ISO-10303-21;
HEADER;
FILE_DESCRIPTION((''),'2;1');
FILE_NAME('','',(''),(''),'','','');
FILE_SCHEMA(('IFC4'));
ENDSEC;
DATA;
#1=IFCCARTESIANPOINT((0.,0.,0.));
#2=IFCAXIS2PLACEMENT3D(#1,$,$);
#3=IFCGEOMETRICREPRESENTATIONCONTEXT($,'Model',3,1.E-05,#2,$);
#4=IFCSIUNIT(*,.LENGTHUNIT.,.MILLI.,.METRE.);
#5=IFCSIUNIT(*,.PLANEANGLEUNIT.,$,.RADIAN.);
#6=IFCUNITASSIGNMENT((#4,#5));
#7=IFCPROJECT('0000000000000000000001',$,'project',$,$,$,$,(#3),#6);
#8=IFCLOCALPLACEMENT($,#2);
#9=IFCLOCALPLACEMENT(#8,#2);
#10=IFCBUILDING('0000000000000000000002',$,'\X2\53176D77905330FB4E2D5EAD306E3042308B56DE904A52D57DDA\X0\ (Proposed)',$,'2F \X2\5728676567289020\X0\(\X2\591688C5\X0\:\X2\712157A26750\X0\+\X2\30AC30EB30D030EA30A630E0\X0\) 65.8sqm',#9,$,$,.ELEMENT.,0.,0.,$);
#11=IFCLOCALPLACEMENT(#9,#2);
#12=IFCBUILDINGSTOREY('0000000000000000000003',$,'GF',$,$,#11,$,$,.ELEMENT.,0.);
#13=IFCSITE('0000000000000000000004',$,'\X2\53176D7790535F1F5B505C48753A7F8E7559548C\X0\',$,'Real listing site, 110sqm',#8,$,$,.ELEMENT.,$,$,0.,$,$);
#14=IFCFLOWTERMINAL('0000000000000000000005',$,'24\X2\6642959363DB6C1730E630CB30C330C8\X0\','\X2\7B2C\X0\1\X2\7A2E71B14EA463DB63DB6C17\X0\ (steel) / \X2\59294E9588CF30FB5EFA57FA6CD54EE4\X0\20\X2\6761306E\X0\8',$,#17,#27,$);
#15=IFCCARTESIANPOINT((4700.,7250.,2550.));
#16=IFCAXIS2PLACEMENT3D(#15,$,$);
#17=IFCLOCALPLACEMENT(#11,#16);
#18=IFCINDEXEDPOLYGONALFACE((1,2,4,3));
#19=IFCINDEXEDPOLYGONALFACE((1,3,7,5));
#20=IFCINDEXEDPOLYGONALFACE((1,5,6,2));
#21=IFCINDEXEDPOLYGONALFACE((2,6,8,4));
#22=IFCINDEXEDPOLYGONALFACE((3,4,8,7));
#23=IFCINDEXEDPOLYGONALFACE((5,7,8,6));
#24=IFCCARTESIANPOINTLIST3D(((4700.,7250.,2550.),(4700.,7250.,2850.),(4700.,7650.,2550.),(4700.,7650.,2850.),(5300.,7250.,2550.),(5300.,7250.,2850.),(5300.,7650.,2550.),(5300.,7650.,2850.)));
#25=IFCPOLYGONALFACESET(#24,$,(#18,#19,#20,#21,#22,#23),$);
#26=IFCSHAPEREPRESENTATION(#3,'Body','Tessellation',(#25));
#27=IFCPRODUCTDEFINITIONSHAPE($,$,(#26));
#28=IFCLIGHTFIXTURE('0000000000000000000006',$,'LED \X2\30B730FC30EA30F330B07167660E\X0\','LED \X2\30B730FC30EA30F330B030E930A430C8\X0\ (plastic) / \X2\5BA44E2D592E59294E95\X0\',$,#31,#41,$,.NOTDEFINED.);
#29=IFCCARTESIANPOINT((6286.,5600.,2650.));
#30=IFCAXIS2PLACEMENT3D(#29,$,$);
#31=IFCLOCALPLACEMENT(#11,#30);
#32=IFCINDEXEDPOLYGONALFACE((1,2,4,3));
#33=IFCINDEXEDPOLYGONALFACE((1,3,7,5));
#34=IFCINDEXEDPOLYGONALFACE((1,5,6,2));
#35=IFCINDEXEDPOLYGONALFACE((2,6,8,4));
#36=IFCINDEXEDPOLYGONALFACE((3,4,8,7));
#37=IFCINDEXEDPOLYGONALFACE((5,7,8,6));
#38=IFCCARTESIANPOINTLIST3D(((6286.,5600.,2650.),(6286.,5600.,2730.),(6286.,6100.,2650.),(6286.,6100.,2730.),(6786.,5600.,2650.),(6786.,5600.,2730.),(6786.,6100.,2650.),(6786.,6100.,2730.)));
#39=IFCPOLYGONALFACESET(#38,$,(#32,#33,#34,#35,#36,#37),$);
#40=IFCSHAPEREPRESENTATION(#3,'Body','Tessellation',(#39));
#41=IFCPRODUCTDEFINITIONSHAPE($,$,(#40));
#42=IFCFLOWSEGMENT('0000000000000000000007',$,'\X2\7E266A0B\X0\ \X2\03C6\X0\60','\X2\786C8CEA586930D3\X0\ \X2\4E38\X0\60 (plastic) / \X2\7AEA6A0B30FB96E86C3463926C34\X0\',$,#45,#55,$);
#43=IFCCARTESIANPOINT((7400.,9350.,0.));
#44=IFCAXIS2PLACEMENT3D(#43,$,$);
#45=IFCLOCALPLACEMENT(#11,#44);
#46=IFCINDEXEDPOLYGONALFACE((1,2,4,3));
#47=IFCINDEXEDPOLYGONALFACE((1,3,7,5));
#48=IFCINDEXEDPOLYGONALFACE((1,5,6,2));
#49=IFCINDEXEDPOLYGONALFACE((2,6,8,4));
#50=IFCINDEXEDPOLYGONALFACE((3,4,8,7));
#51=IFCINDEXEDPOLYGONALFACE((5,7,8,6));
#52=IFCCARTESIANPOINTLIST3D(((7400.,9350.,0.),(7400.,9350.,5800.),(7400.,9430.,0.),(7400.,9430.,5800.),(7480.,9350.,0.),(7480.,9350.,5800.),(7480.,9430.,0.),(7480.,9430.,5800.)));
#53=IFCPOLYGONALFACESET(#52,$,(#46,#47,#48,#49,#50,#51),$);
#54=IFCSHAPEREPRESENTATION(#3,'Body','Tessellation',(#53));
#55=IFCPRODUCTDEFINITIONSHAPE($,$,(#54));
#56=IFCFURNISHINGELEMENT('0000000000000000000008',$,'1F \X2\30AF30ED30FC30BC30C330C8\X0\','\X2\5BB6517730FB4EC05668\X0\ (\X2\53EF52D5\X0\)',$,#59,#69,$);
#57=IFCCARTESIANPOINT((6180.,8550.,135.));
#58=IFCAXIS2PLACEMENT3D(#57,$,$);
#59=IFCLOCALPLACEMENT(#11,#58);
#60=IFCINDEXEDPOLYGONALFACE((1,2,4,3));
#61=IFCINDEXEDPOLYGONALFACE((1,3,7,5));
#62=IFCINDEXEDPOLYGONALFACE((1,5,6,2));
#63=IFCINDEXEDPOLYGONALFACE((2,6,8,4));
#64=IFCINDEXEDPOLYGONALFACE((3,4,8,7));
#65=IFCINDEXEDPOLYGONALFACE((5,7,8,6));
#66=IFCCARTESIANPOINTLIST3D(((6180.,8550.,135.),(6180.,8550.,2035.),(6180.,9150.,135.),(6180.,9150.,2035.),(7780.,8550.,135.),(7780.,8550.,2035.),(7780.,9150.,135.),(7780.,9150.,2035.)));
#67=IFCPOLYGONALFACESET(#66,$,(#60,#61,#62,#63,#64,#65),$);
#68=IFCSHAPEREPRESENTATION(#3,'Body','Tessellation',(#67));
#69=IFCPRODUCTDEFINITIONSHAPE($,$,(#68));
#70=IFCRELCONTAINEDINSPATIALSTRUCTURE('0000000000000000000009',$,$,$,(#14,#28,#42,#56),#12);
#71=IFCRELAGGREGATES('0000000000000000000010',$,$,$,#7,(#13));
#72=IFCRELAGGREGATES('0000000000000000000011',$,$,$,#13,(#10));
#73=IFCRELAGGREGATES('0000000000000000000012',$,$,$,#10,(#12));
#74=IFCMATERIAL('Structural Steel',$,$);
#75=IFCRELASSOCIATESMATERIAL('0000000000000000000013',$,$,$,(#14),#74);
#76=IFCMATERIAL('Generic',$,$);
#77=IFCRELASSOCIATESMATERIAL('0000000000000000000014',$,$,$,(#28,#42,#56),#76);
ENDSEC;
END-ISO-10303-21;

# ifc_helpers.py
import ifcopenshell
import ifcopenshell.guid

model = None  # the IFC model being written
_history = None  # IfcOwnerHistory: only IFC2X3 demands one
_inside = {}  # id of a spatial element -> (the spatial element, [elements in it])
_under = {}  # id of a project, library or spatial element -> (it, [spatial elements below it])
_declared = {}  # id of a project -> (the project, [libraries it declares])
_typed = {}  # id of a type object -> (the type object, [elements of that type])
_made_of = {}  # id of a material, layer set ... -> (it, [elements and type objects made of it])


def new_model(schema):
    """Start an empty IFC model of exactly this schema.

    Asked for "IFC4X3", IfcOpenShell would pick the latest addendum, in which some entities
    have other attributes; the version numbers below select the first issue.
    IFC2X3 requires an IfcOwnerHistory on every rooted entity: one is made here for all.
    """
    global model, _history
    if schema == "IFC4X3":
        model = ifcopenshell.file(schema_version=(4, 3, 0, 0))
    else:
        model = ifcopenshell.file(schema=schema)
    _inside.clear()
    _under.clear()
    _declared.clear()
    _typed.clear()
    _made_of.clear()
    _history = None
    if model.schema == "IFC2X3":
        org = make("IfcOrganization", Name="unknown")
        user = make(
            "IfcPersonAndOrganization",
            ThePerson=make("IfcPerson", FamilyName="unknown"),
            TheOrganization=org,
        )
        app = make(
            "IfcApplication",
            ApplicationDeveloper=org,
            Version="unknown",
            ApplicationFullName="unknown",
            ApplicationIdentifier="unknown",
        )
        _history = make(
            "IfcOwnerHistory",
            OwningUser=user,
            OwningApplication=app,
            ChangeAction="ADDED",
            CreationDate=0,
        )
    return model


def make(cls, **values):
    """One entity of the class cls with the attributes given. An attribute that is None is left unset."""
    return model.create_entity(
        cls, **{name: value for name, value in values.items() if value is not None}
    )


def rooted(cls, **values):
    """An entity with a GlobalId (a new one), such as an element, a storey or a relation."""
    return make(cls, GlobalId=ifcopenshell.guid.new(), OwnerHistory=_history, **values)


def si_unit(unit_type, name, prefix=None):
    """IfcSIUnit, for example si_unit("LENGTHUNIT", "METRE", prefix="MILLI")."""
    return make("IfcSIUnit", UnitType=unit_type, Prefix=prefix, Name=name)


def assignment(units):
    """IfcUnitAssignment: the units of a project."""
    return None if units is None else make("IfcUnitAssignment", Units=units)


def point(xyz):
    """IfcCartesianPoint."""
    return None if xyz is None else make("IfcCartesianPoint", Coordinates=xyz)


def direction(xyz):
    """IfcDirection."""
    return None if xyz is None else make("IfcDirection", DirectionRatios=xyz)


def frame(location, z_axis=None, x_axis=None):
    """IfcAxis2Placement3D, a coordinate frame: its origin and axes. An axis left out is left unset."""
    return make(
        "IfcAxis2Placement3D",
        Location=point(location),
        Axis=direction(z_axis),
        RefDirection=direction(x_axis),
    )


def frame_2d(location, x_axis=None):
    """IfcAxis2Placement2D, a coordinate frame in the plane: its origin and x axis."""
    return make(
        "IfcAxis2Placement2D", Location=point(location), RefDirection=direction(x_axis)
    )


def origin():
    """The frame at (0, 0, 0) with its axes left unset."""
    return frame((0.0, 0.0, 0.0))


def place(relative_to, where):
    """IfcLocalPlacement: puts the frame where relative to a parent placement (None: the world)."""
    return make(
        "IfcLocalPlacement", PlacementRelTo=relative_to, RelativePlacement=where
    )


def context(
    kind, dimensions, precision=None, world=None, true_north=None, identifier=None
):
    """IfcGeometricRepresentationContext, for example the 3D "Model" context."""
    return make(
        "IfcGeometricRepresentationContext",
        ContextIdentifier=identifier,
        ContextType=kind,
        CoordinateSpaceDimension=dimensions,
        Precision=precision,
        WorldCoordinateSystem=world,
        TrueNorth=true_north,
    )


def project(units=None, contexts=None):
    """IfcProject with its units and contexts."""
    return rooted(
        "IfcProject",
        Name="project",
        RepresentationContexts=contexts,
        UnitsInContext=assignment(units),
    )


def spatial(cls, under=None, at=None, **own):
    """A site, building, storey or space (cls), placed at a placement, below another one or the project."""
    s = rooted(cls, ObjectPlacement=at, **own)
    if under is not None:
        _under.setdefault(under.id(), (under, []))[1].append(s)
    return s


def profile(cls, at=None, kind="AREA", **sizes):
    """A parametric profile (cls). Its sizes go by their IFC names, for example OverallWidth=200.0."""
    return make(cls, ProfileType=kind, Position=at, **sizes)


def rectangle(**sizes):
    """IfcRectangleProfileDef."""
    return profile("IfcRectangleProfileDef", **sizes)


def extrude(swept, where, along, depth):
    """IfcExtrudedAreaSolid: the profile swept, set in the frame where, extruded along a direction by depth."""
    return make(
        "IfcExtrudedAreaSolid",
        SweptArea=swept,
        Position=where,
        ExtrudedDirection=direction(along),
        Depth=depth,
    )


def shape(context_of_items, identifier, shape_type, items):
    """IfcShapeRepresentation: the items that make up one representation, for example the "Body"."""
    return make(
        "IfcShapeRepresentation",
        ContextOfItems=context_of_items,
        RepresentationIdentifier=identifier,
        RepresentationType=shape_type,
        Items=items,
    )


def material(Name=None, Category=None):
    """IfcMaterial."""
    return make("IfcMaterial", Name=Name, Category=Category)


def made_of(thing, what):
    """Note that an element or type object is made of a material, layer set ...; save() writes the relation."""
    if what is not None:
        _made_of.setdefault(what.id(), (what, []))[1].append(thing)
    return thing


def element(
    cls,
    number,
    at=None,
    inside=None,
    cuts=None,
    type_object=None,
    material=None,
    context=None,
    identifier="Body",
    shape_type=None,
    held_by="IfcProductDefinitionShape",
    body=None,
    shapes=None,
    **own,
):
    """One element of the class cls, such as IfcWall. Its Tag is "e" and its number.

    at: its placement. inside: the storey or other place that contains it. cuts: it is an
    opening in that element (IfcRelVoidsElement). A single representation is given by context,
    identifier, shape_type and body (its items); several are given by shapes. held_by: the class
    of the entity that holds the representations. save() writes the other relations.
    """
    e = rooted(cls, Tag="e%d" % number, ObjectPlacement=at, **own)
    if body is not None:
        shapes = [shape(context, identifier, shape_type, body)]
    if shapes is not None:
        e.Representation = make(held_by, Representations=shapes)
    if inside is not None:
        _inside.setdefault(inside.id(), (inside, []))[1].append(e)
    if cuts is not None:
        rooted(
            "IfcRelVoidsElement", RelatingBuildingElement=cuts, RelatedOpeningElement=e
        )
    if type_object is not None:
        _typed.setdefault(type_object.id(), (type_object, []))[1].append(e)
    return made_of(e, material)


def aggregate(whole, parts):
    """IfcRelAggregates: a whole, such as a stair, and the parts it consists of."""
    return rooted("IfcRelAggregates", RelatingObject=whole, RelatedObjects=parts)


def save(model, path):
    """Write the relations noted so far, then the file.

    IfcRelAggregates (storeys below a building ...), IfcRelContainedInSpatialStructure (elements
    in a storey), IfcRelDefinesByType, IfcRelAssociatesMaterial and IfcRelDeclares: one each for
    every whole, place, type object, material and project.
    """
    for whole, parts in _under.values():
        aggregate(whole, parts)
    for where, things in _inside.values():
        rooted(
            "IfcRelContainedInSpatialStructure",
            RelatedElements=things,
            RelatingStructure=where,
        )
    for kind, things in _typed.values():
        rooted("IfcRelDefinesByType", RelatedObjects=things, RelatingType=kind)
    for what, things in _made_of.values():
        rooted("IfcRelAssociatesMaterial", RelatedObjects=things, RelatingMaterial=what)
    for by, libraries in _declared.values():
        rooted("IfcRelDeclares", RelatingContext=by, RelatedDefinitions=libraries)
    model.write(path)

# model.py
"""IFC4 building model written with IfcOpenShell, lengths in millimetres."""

from ifc_helpers import new_model, si_unit, frame, frame_2d, origin, place, context, project, spatial, rectangle, extrude, material, element, save


model = new_model("IFC4")

# Units and contexts
model_context = context("Model", 3, precision=1e-05, world=origin())
ifc_project = project(units=[si_unit("LENGTHUNIT", "METRE", prefix="MILLI"), si_unit("PLANEANGLEUNIT", "RADIAN")], contexts=[model_context])

# Site, building, storey
site_placement = place(None, origin())
site = spatial("IfcSite", under=ifc_project, at=site_placement, Name="北海道弟子屈町美留和", ObjectType="Real listing site, 110sqm", CompositionType="ELEMENT", RefElevation=0.0)
building_placement = place(site_placement, origin())
building = spatial("IfcBuilding", under=site, at=building_placement, Name="北海道・中庭のある回遊動線 (Proposed)", ObjectType="2F 在来木造(外装:無垢材+ガルバリウム) 65.8sqm", CompositionType="ELEMENT", ElevationOfRefHeight=0.0, ElevationOfTerrain=0.0)
storey_placement = place(building_placement, origin())
storey = spatial("IfcBuildingStorey", under=building, at=storey_placement, Name="GF", CompositionType="ELEMENT", Elevation=0.0)

# Shared definitions
ifc_material_1 = material(Name="Generic")

# Flow terminal
ifc_material_2 = material(Name="Structural Steel")
flow_terminal_placement = place(storey_placement, frame((4700.0, 7250.0, 2550.0)))
element("IfcFlowTerminal", 1, at=flow_terminal_placement, inside=storey, material=ifc_material_2, Name="24時間換気ユニット", Description="第1種熱交換換気 (steel) / 天井裏・建基法令20条の8", context=model_context, shape_type="SweptSolid", body=[
    extrude(rectangle(XDim=600.0, YDim=400.0, at=frame_2d((300.0, 200.0))), frame((4700.0, 7250.0, 2550.0)), (0.0, 0.0, 1.0), 300.0),
])

# Light fixture
light_fixture_placement = place(storey_placement, frame((6286.0, 5600.0, 2650.0)))
element("IfcLightFixture", 2, at=light_fixture_placement, inside=storey, material=ifc_material_1, Name="LED シーリング照明", Description="LED シーリングライト (plastic) / 室中央天井", PredefinedType="NOTDEFINED", context=model_context, shape_type="SweptSolid", body=[
    extrude(rectangle(XDim=500.0, YDim=500.0, at=frame_2d((250.0, 250.0))), frame((6286.0, 5600.0, 2650.0)), (0.0, 0.0, 1.0), 80.0),
])

# Flow segment
flow_segment_placement = place(storey_placement, frame((7400.0, 9350.0, 0.0)))
element("IfcFlowSegment", 3, at=flow_segment_placement, inside=storey, material=ifc_material_1, Name="縦樋 φ60", Description="硬質塩ビ 丸60 (plastic) / 竪樋・雨水排水", context=model_context, shape_type="SweptSolid", body=[
    extrude(rectangle(XDim=80.0, YDim=80.0, at=frame_2d((40.0, 40.0))), frame((7400.0, 9350.0, 0.0)), (0.0, 0.0, 1.0), 5800.0),
])

# Furnishing element
furnishing_placement = place(storey_placement, frame((6180.0, 8550.0, 135.0)))
element("IfcFurnishingElement", 4, at=furnishing_placement, inside=storey, material=ifc_material_1, Name="1F クローゼット", Description="家具・什器 (可動)", context=model_context, shape_type="SweptSolid", body=[
    extrude(rectangle(XDim=1600.0, YDim=600.0, at=frame_2d((800.0, 300.0))), frame((6180.0, 8550.0, 135.0)), (0.0, 0.0, 1.0), 1900.0),
])

save(model, "model.ifc")
